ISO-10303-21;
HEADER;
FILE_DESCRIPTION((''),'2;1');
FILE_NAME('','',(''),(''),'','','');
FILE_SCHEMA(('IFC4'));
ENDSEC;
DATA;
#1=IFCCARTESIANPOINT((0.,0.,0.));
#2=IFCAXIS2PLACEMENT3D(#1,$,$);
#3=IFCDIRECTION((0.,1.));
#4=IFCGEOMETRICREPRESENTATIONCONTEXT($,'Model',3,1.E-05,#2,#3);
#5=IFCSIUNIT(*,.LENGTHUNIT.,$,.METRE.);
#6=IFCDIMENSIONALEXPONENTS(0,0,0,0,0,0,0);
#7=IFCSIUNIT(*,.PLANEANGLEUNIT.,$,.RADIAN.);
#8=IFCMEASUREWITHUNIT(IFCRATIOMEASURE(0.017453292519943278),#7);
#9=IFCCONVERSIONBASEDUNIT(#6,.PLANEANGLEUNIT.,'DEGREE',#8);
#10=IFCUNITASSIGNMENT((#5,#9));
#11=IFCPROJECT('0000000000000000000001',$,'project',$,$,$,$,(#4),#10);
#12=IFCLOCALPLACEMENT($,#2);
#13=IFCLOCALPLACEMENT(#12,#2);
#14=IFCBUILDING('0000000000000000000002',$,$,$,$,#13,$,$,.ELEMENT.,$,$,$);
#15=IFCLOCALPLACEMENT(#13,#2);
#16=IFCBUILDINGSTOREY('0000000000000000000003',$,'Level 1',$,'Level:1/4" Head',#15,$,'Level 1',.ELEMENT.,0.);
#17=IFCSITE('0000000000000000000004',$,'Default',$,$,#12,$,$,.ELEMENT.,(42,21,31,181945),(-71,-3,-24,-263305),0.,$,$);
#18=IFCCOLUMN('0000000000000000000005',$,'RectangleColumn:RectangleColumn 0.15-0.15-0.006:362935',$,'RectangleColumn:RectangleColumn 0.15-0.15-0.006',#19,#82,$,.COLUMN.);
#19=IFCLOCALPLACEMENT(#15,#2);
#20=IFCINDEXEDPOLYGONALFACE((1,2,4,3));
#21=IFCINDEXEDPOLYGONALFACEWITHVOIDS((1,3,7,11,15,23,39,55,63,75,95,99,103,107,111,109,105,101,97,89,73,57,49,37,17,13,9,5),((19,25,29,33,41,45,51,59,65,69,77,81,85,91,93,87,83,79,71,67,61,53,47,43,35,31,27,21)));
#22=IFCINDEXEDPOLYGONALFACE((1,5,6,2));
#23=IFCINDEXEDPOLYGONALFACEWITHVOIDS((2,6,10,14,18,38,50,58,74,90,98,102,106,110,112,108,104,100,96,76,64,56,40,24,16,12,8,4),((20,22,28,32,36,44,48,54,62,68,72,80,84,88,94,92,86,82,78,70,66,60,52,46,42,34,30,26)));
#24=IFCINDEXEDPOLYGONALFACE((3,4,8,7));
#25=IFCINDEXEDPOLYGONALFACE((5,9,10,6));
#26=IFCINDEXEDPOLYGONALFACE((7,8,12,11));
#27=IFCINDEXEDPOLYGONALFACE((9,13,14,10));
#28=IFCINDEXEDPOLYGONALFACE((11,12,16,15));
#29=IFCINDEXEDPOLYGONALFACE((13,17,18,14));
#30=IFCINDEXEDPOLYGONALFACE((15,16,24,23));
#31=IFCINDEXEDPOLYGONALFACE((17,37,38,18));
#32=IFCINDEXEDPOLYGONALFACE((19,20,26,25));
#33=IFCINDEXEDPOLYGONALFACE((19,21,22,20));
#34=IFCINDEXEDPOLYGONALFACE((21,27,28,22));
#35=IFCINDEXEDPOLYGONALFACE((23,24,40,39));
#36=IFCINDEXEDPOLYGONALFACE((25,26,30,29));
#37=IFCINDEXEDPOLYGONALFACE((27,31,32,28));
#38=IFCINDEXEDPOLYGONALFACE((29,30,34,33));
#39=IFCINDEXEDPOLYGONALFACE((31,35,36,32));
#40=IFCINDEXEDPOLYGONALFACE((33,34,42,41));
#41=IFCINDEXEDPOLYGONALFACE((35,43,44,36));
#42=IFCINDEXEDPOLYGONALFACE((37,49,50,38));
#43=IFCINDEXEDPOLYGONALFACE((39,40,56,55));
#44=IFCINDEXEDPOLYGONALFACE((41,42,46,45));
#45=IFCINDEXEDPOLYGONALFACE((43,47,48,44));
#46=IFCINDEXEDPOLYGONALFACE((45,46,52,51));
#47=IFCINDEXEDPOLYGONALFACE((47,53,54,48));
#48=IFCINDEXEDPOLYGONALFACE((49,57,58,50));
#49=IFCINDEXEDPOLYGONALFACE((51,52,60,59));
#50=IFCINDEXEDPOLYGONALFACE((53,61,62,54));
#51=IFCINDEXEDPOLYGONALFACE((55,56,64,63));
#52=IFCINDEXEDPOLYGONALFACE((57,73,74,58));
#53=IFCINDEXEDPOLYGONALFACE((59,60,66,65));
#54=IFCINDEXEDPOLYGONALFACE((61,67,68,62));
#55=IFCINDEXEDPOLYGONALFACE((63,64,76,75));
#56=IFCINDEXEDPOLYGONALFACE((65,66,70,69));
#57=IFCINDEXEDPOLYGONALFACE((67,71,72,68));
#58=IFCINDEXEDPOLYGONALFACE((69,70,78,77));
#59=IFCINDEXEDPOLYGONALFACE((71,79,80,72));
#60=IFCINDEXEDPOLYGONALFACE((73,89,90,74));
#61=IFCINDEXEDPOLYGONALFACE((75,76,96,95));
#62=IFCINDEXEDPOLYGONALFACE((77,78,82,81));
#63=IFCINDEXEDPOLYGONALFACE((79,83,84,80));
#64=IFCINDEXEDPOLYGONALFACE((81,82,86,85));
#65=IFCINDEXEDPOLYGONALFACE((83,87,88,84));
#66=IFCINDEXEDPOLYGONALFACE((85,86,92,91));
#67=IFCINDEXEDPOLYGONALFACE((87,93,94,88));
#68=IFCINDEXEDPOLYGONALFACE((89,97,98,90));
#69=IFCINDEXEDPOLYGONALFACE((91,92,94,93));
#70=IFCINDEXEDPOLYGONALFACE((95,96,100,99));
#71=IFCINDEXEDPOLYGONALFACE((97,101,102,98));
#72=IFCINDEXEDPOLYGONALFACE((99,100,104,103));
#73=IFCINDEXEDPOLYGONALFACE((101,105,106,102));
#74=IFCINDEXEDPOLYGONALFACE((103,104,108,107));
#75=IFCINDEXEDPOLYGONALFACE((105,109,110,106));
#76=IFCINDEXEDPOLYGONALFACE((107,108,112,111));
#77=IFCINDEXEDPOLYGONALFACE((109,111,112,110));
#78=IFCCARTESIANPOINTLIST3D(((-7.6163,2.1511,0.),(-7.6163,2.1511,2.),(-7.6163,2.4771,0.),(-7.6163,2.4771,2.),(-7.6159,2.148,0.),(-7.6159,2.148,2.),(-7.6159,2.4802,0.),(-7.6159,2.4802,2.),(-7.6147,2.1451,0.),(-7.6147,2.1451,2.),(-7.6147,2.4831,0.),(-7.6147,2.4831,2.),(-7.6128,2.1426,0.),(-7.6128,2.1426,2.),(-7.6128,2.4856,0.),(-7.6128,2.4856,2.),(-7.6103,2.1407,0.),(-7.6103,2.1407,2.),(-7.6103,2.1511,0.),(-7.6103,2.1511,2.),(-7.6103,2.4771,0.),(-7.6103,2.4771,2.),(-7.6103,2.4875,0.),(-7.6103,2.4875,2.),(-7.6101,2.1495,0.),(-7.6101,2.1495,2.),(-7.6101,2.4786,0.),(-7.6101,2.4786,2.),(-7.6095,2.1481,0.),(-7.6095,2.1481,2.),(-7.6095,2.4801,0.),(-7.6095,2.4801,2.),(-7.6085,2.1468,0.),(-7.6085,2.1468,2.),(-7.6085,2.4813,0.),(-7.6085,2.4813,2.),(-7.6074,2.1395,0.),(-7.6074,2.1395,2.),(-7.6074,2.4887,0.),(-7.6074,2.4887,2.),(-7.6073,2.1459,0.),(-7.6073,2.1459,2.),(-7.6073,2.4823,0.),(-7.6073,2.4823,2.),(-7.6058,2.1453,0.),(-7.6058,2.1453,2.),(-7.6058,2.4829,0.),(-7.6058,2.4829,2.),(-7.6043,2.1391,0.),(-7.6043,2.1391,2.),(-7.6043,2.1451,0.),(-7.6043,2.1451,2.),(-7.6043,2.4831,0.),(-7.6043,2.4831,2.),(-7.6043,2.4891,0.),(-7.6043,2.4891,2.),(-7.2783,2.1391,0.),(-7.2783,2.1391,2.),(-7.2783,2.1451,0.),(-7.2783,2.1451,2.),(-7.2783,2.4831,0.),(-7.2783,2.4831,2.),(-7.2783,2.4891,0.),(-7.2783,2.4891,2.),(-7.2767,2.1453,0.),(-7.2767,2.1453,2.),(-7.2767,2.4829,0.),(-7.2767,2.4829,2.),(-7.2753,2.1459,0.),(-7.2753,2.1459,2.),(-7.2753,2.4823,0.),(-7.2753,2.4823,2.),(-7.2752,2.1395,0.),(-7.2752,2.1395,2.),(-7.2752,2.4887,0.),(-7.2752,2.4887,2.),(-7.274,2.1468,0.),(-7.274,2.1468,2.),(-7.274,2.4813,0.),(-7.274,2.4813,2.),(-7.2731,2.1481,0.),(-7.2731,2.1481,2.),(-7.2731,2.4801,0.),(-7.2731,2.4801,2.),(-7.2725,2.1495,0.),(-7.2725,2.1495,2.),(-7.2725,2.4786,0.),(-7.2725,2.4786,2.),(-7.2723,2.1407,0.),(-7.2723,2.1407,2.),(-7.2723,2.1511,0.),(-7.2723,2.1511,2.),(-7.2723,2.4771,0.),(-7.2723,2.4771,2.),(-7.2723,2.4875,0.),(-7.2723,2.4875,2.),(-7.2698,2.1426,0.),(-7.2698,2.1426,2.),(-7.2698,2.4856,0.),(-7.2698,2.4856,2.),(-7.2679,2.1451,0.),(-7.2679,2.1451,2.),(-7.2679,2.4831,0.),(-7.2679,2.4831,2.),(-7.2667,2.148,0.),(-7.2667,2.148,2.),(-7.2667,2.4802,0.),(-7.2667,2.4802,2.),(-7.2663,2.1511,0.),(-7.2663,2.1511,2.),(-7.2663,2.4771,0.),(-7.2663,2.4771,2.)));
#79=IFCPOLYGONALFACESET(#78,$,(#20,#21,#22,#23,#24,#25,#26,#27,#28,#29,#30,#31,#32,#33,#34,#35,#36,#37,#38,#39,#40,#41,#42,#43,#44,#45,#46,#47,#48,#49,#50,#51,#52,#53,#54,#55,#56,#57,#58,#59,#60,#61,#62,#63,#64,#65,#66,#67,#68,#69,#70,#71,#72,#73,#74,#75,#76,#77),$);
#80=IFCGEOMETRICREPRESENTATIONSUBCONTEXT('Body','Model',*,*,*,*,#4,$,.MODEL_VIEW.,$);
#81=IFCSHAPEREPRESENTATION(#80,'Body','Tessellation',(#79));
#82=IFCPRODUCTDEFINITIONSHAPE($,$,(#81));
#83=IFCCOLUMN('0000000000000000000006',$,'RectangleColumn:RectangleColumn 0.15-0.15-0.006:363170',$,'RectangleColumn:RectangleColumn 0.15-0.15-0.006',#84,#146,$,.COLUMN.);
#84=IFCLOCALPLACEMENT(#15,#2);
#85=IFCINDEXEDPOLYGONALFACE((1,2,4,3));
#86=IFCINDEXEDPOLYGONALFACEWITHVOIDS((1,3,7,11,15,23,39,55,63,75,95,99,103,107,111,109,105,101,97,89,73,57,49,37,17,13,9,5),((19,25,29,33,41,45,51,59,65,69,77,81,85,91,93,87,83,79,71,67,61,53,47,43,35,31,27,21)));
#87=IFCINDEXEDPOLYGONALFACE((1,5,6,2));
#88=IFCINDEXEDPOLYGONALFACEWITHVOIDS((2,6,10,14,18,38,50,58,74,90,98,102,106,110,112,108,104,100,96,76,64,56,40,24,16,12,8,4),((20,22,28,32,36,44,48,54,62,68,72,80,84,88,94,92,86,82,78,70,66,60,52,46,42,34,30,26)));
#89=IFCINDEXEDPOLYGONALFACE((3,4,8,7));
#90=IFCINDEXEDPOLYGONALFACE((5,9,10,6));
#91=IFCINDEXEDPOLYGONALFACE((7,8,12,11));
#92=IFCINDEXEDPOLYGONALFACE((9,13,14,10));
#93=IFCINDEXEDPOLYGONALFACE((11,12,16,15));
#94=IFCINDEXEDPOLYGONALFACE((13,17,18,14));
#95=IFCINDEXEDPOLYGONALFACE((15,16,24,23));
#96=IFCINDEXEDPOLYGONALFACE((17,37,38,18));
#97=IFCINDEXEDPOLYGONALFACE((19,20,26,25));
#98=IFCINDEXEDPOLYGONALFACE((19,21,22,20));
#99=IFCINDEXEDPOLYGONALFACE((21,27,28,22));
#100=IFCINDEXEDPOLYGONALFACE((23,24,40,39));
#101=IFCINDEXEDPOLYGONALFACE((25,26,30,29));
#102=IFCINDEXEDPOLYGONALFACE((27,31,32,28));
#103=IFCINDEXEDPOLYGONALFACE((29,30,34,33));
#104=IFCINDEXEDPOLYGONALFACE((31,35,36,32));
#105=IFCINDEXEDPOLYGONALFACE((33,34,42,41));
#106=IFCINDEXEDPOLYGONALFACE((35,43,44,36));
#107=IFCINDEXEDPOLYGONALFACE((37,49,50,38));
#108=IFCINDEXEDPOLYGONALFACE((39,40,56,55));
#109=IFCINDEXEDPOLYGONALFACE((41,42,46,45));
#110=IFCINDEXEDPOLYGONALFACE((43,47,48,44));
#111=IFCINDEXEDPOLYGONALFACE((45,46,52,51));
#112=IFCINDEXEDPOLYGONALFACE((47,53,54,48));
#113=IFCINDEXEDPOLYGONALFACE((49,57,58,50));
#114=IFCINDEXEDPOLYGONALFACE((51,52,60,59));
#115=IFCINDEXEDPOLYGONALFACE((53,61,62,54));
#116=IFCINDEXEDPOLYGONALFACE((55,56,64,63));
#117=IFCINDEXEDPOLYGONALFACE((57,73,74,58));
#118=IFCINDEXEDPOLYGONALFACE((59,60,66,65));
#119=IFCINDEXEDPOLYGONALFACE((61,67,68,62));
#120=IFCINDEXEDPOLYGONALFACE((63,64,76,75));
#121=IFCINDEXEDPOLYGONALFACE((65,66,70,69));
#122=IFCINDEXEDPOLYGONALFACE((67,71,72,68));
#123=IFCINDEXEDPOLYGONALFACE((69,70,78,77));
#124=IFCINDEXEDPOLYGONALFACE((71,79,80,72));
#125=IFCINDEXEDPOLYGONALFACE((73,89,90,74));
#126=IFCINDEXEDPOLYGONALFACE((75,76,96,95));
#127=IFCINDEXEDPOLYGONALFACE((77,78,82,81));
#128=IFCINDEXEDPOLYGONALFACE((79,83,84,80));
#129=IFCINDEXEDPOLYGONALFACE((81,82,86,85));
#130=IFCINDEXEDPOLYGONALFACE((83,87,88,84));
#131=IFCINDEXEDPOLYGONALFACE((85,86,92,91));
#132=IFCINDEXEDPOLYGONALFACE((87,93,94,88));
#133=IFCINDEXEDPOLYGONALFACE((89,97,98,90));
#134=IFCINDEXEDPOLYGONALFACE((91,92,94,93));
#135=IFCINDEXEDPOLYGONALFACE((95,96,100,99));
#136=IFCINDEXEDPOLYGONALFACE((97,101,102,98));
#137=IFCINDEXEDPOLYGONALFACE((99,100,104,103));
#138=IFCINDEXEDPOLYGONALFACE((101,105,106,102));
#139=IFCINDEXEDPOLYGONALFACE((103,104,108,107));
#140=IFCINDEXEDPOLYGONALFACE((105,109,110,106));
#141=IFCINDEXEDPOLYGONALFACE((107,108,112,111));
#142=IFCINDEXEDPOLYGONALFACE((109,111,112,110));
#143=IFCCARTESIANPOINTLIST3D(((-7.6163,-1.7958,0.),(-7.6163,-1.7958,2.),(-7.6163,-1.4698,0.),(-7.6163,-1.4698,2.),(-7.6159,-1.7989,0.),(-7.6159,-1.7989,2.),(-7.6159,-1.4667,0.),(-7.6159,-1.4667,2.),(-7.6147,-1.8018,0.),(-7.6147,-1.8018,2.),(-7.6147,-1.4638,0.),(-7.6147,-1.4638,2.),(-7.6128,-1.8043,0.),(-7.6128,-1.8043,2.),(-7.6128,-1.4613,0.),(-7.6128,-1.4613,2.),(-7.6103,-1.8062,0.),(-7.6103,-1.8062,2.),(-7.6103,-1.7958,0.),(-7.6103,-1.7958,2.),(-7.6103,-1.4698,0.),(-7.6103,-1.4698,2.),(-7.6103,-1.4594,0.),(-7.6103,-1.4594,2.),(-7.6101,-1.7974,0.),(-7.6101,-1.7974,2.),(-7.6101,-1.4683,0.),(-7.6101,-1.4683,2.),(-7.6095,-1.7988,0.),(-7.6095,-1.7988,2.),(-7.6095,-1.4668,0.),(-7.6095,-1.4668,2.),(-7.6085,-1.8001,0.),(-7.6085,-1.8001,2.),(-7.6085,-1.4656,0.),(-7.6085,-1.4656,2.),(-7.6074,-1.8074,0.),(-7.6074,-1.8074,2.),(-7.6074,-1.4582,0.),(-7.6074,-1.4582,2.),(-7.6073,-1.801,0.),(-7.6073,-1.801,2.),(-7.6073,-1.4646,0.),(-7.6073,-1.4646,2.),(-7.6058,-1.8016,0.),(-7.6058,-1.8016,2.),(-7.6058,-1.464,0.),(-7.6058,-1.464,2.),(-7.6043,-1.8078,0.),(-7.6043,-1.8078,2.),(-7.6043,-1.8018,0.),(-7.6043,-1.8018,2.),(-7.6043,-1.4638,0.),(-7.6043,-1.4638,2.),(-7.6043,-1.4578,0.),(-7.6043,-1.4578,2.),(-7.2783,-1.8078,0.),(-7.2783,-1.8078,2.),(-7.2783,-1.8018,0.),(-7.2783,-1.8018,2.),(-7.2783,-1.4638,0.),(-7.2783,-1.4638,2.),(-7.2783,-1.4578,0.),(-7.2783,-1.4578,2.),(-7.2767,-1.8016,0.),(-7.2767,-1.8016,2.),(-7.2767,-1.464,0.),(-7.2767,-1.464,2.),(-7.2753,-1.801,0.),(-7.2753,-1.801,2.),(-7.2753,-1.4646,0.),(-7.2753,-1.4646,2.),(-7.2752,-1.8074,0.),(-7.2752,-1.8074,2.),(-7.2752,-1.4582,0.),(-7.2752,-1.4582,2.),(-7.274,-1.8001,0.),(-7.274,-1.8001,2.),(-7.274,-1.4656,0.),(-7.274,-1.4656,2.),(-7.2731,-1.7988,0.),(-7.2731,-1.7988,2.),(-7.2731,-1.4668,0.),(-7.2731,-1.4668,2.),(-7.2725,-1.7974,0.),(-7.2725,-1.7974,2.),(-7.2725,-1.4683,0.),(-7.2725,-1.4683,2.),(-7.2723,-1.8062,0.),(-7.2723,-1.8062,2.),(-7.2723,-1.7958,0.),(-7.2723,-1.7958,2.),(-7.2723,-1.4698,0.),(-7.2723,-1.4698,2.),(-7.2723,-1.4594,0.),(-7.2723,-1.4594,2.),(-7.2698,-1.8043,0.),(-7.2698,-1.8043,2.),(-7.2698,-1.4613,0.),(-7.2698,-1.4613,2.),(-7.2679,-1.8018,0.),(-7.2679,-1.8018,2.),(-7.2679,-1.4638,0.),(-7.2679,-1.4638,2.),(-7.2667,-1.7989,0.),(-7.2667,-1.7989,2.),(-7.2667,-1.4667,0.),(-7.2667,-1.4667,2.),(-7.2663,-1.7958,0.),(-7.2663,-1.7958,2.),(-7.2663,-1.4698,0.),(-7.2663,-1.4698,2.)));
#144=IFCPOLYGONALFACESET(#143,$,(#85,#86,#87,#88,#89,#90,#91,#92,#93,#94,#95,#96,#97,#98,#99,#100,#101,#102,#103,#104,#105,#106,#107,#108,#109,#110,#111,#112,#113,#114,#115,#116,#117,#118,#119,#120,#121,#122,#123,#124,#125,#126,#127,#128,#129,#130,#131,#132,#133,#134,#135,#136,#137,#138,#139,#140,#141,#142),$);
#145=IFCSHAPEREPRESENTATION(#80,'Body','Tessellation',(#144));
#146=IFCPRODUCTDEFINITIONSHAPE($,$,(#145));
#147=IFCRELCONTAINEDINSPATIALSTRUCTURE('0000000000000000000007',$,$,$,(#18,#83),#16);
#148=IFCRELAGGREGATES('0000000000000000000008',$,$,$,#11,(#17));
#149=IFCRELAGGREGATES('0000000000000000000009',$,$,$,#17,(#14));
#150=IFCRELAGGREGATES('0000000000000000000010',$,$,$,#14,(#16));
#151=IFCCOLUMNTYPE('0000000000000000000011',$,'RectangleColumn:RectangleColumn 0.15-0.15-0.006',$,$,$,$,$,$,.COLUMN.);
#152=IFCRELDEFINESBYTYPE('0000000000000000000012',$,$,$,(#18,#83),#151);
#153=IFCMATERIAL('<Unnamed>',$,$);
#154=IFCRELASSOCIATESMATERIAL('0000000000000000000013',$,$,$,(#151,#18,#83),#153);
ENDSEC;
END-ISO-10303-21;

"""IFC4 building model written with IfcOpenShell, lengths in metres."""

from ifc_helpers import new_model, entity, si_unit, converted_unit, direction, frame, origin, place, context, subcontext, project, spatial, line, arc, indexed_curve, outline, extrude, source, transform, mapped, material, type_object, type_shapes, element, save


model = new_model("IFC4")

# Units and contexts
model_context = context("Model", 3, precision=1e-05, world=origin(), true_north=direction((0.0, 1.0)))
body_context = subcontext(model_context, "Body", "Model", "MODEL_VIEW")
ifc_project = project(units=[si_unit("LENGTHUNIT", "METRE"), converted_unit("PLANEANGLEUNIT", "DEGREE", entity("IfcRatioMeasure", 0.017453292519943278), si_unit("PLANEANGLEUNIT", "RADIAN"), dimensions=[0, 0, 0, 0, 0, 0, 0])], contexts=[model_context])

# Site, building, storey
site_placement = place(None, origin())
site = spatial("IfcSite", under=ifc_project, at=site_placement, Name="Default", CompositionType="ELEMENT", RefLatitude=(42, 21, 31, 181945), RefLongitude=(-71, -3, -24, -263305), RefElevation=0.0)
building_placement = place(site_placement, origin())
building = spatial("IfcBuilding", under=site, at=building_placement, CompositionType="ELEMENT")
storey_placement = place(building_placement, origin())
storey = spatial("IfcBuildingStorey", under=building, at=storey_placement, Name="Level 1", ObjectType="Level:1/4\" Head", LongName="Level 1", CompositionType="ELEMENT", Elevation=0.0)

# Columns
ifc_material_1 = material(Name="<Unnamed>")
column_type = type_object("IfcColumnType", Name="RectangleColumn:RectangleColumn 0.15-0.15-0.006", PredefinedType="COLUMN", material=ifc_material_1)
shared_shape = source(origin(), body_context, "Body", "SweptSolid", [
    extrude(outline(indexed_curve([(-0.163, -0.175), (0.163, -0.175), (0.1715, -0.1715), (0.175, -0.163), (0.175, 0.163), (0.1715, 0.1715), (0.163, 0.175), (-0.163, 0.175), (-0.1715, 0.1715), (-0.175, 0.163), (-0.175, -0.163), (-0.1715, -0.1715)], segments=[line(1, 2), arc(2, 3, 4), line(4, 5), arc(5, 6, 7), line(7, 8), arc(8, 9, 10), line(10, 11), arc(11, 12, 1)], self_intersect=False), holes=[indexed_curve([(-0.163, -0.169), (-0.1672, -0.1672), (-0.169, -0.163), (-0.169, 0.163), (-0.1672, 0.1672), (-0.163, 0.169), (0.163, 0.169), (0.1672, 0.1672), (0.169, 0.163), (0.169, -0.163), (0.1672, -0.1672), (0.163, -0.169)], segments=[arc(1, 2, 3), line(3, 4), arc(4, 5, 6), line(6, 7), arc(7, 8, 9), line(9, 10), arc(10, 11, 12), line(12, 1)], self_intersect=False)]), frame((0.0, 0.0, 0.0), z_axis=(0.0, 0.0, 1.0), x_axis=(-1.0, 0.0, 0.0)), (0.0, 0.0, 1.0), 2.0),
])
type_shapes(column_type, [shared_shape])
for number, where, name in (
    (1, (-7.4413, 2.3141, 0.0), "RectangleColumn:RectangleColumn 0.15-0.15-0.006:362935"),
    (2, (-7.4413, -1.6328, 0.0), "RectangleColumn:RectangleColumn 0.15-0.15-0.006:363170"),
):
    element("IfcColumn", number, at=place(storey_placement, frame(where)), inside=storey, type_object=column_type, material=ifc_material_1, Name=name, ObjectType="RectangleColumn:RectangleColumn 0.15-0.15-0.006", PredefinedType="COLUMN", context=body_context, shape_type="MappedRepresentation", body=[
        mapped(shared_shape, transform((0.0, 0.0, 0.0), scale=1.0)),
    ])

save(model, "model.ifc")
